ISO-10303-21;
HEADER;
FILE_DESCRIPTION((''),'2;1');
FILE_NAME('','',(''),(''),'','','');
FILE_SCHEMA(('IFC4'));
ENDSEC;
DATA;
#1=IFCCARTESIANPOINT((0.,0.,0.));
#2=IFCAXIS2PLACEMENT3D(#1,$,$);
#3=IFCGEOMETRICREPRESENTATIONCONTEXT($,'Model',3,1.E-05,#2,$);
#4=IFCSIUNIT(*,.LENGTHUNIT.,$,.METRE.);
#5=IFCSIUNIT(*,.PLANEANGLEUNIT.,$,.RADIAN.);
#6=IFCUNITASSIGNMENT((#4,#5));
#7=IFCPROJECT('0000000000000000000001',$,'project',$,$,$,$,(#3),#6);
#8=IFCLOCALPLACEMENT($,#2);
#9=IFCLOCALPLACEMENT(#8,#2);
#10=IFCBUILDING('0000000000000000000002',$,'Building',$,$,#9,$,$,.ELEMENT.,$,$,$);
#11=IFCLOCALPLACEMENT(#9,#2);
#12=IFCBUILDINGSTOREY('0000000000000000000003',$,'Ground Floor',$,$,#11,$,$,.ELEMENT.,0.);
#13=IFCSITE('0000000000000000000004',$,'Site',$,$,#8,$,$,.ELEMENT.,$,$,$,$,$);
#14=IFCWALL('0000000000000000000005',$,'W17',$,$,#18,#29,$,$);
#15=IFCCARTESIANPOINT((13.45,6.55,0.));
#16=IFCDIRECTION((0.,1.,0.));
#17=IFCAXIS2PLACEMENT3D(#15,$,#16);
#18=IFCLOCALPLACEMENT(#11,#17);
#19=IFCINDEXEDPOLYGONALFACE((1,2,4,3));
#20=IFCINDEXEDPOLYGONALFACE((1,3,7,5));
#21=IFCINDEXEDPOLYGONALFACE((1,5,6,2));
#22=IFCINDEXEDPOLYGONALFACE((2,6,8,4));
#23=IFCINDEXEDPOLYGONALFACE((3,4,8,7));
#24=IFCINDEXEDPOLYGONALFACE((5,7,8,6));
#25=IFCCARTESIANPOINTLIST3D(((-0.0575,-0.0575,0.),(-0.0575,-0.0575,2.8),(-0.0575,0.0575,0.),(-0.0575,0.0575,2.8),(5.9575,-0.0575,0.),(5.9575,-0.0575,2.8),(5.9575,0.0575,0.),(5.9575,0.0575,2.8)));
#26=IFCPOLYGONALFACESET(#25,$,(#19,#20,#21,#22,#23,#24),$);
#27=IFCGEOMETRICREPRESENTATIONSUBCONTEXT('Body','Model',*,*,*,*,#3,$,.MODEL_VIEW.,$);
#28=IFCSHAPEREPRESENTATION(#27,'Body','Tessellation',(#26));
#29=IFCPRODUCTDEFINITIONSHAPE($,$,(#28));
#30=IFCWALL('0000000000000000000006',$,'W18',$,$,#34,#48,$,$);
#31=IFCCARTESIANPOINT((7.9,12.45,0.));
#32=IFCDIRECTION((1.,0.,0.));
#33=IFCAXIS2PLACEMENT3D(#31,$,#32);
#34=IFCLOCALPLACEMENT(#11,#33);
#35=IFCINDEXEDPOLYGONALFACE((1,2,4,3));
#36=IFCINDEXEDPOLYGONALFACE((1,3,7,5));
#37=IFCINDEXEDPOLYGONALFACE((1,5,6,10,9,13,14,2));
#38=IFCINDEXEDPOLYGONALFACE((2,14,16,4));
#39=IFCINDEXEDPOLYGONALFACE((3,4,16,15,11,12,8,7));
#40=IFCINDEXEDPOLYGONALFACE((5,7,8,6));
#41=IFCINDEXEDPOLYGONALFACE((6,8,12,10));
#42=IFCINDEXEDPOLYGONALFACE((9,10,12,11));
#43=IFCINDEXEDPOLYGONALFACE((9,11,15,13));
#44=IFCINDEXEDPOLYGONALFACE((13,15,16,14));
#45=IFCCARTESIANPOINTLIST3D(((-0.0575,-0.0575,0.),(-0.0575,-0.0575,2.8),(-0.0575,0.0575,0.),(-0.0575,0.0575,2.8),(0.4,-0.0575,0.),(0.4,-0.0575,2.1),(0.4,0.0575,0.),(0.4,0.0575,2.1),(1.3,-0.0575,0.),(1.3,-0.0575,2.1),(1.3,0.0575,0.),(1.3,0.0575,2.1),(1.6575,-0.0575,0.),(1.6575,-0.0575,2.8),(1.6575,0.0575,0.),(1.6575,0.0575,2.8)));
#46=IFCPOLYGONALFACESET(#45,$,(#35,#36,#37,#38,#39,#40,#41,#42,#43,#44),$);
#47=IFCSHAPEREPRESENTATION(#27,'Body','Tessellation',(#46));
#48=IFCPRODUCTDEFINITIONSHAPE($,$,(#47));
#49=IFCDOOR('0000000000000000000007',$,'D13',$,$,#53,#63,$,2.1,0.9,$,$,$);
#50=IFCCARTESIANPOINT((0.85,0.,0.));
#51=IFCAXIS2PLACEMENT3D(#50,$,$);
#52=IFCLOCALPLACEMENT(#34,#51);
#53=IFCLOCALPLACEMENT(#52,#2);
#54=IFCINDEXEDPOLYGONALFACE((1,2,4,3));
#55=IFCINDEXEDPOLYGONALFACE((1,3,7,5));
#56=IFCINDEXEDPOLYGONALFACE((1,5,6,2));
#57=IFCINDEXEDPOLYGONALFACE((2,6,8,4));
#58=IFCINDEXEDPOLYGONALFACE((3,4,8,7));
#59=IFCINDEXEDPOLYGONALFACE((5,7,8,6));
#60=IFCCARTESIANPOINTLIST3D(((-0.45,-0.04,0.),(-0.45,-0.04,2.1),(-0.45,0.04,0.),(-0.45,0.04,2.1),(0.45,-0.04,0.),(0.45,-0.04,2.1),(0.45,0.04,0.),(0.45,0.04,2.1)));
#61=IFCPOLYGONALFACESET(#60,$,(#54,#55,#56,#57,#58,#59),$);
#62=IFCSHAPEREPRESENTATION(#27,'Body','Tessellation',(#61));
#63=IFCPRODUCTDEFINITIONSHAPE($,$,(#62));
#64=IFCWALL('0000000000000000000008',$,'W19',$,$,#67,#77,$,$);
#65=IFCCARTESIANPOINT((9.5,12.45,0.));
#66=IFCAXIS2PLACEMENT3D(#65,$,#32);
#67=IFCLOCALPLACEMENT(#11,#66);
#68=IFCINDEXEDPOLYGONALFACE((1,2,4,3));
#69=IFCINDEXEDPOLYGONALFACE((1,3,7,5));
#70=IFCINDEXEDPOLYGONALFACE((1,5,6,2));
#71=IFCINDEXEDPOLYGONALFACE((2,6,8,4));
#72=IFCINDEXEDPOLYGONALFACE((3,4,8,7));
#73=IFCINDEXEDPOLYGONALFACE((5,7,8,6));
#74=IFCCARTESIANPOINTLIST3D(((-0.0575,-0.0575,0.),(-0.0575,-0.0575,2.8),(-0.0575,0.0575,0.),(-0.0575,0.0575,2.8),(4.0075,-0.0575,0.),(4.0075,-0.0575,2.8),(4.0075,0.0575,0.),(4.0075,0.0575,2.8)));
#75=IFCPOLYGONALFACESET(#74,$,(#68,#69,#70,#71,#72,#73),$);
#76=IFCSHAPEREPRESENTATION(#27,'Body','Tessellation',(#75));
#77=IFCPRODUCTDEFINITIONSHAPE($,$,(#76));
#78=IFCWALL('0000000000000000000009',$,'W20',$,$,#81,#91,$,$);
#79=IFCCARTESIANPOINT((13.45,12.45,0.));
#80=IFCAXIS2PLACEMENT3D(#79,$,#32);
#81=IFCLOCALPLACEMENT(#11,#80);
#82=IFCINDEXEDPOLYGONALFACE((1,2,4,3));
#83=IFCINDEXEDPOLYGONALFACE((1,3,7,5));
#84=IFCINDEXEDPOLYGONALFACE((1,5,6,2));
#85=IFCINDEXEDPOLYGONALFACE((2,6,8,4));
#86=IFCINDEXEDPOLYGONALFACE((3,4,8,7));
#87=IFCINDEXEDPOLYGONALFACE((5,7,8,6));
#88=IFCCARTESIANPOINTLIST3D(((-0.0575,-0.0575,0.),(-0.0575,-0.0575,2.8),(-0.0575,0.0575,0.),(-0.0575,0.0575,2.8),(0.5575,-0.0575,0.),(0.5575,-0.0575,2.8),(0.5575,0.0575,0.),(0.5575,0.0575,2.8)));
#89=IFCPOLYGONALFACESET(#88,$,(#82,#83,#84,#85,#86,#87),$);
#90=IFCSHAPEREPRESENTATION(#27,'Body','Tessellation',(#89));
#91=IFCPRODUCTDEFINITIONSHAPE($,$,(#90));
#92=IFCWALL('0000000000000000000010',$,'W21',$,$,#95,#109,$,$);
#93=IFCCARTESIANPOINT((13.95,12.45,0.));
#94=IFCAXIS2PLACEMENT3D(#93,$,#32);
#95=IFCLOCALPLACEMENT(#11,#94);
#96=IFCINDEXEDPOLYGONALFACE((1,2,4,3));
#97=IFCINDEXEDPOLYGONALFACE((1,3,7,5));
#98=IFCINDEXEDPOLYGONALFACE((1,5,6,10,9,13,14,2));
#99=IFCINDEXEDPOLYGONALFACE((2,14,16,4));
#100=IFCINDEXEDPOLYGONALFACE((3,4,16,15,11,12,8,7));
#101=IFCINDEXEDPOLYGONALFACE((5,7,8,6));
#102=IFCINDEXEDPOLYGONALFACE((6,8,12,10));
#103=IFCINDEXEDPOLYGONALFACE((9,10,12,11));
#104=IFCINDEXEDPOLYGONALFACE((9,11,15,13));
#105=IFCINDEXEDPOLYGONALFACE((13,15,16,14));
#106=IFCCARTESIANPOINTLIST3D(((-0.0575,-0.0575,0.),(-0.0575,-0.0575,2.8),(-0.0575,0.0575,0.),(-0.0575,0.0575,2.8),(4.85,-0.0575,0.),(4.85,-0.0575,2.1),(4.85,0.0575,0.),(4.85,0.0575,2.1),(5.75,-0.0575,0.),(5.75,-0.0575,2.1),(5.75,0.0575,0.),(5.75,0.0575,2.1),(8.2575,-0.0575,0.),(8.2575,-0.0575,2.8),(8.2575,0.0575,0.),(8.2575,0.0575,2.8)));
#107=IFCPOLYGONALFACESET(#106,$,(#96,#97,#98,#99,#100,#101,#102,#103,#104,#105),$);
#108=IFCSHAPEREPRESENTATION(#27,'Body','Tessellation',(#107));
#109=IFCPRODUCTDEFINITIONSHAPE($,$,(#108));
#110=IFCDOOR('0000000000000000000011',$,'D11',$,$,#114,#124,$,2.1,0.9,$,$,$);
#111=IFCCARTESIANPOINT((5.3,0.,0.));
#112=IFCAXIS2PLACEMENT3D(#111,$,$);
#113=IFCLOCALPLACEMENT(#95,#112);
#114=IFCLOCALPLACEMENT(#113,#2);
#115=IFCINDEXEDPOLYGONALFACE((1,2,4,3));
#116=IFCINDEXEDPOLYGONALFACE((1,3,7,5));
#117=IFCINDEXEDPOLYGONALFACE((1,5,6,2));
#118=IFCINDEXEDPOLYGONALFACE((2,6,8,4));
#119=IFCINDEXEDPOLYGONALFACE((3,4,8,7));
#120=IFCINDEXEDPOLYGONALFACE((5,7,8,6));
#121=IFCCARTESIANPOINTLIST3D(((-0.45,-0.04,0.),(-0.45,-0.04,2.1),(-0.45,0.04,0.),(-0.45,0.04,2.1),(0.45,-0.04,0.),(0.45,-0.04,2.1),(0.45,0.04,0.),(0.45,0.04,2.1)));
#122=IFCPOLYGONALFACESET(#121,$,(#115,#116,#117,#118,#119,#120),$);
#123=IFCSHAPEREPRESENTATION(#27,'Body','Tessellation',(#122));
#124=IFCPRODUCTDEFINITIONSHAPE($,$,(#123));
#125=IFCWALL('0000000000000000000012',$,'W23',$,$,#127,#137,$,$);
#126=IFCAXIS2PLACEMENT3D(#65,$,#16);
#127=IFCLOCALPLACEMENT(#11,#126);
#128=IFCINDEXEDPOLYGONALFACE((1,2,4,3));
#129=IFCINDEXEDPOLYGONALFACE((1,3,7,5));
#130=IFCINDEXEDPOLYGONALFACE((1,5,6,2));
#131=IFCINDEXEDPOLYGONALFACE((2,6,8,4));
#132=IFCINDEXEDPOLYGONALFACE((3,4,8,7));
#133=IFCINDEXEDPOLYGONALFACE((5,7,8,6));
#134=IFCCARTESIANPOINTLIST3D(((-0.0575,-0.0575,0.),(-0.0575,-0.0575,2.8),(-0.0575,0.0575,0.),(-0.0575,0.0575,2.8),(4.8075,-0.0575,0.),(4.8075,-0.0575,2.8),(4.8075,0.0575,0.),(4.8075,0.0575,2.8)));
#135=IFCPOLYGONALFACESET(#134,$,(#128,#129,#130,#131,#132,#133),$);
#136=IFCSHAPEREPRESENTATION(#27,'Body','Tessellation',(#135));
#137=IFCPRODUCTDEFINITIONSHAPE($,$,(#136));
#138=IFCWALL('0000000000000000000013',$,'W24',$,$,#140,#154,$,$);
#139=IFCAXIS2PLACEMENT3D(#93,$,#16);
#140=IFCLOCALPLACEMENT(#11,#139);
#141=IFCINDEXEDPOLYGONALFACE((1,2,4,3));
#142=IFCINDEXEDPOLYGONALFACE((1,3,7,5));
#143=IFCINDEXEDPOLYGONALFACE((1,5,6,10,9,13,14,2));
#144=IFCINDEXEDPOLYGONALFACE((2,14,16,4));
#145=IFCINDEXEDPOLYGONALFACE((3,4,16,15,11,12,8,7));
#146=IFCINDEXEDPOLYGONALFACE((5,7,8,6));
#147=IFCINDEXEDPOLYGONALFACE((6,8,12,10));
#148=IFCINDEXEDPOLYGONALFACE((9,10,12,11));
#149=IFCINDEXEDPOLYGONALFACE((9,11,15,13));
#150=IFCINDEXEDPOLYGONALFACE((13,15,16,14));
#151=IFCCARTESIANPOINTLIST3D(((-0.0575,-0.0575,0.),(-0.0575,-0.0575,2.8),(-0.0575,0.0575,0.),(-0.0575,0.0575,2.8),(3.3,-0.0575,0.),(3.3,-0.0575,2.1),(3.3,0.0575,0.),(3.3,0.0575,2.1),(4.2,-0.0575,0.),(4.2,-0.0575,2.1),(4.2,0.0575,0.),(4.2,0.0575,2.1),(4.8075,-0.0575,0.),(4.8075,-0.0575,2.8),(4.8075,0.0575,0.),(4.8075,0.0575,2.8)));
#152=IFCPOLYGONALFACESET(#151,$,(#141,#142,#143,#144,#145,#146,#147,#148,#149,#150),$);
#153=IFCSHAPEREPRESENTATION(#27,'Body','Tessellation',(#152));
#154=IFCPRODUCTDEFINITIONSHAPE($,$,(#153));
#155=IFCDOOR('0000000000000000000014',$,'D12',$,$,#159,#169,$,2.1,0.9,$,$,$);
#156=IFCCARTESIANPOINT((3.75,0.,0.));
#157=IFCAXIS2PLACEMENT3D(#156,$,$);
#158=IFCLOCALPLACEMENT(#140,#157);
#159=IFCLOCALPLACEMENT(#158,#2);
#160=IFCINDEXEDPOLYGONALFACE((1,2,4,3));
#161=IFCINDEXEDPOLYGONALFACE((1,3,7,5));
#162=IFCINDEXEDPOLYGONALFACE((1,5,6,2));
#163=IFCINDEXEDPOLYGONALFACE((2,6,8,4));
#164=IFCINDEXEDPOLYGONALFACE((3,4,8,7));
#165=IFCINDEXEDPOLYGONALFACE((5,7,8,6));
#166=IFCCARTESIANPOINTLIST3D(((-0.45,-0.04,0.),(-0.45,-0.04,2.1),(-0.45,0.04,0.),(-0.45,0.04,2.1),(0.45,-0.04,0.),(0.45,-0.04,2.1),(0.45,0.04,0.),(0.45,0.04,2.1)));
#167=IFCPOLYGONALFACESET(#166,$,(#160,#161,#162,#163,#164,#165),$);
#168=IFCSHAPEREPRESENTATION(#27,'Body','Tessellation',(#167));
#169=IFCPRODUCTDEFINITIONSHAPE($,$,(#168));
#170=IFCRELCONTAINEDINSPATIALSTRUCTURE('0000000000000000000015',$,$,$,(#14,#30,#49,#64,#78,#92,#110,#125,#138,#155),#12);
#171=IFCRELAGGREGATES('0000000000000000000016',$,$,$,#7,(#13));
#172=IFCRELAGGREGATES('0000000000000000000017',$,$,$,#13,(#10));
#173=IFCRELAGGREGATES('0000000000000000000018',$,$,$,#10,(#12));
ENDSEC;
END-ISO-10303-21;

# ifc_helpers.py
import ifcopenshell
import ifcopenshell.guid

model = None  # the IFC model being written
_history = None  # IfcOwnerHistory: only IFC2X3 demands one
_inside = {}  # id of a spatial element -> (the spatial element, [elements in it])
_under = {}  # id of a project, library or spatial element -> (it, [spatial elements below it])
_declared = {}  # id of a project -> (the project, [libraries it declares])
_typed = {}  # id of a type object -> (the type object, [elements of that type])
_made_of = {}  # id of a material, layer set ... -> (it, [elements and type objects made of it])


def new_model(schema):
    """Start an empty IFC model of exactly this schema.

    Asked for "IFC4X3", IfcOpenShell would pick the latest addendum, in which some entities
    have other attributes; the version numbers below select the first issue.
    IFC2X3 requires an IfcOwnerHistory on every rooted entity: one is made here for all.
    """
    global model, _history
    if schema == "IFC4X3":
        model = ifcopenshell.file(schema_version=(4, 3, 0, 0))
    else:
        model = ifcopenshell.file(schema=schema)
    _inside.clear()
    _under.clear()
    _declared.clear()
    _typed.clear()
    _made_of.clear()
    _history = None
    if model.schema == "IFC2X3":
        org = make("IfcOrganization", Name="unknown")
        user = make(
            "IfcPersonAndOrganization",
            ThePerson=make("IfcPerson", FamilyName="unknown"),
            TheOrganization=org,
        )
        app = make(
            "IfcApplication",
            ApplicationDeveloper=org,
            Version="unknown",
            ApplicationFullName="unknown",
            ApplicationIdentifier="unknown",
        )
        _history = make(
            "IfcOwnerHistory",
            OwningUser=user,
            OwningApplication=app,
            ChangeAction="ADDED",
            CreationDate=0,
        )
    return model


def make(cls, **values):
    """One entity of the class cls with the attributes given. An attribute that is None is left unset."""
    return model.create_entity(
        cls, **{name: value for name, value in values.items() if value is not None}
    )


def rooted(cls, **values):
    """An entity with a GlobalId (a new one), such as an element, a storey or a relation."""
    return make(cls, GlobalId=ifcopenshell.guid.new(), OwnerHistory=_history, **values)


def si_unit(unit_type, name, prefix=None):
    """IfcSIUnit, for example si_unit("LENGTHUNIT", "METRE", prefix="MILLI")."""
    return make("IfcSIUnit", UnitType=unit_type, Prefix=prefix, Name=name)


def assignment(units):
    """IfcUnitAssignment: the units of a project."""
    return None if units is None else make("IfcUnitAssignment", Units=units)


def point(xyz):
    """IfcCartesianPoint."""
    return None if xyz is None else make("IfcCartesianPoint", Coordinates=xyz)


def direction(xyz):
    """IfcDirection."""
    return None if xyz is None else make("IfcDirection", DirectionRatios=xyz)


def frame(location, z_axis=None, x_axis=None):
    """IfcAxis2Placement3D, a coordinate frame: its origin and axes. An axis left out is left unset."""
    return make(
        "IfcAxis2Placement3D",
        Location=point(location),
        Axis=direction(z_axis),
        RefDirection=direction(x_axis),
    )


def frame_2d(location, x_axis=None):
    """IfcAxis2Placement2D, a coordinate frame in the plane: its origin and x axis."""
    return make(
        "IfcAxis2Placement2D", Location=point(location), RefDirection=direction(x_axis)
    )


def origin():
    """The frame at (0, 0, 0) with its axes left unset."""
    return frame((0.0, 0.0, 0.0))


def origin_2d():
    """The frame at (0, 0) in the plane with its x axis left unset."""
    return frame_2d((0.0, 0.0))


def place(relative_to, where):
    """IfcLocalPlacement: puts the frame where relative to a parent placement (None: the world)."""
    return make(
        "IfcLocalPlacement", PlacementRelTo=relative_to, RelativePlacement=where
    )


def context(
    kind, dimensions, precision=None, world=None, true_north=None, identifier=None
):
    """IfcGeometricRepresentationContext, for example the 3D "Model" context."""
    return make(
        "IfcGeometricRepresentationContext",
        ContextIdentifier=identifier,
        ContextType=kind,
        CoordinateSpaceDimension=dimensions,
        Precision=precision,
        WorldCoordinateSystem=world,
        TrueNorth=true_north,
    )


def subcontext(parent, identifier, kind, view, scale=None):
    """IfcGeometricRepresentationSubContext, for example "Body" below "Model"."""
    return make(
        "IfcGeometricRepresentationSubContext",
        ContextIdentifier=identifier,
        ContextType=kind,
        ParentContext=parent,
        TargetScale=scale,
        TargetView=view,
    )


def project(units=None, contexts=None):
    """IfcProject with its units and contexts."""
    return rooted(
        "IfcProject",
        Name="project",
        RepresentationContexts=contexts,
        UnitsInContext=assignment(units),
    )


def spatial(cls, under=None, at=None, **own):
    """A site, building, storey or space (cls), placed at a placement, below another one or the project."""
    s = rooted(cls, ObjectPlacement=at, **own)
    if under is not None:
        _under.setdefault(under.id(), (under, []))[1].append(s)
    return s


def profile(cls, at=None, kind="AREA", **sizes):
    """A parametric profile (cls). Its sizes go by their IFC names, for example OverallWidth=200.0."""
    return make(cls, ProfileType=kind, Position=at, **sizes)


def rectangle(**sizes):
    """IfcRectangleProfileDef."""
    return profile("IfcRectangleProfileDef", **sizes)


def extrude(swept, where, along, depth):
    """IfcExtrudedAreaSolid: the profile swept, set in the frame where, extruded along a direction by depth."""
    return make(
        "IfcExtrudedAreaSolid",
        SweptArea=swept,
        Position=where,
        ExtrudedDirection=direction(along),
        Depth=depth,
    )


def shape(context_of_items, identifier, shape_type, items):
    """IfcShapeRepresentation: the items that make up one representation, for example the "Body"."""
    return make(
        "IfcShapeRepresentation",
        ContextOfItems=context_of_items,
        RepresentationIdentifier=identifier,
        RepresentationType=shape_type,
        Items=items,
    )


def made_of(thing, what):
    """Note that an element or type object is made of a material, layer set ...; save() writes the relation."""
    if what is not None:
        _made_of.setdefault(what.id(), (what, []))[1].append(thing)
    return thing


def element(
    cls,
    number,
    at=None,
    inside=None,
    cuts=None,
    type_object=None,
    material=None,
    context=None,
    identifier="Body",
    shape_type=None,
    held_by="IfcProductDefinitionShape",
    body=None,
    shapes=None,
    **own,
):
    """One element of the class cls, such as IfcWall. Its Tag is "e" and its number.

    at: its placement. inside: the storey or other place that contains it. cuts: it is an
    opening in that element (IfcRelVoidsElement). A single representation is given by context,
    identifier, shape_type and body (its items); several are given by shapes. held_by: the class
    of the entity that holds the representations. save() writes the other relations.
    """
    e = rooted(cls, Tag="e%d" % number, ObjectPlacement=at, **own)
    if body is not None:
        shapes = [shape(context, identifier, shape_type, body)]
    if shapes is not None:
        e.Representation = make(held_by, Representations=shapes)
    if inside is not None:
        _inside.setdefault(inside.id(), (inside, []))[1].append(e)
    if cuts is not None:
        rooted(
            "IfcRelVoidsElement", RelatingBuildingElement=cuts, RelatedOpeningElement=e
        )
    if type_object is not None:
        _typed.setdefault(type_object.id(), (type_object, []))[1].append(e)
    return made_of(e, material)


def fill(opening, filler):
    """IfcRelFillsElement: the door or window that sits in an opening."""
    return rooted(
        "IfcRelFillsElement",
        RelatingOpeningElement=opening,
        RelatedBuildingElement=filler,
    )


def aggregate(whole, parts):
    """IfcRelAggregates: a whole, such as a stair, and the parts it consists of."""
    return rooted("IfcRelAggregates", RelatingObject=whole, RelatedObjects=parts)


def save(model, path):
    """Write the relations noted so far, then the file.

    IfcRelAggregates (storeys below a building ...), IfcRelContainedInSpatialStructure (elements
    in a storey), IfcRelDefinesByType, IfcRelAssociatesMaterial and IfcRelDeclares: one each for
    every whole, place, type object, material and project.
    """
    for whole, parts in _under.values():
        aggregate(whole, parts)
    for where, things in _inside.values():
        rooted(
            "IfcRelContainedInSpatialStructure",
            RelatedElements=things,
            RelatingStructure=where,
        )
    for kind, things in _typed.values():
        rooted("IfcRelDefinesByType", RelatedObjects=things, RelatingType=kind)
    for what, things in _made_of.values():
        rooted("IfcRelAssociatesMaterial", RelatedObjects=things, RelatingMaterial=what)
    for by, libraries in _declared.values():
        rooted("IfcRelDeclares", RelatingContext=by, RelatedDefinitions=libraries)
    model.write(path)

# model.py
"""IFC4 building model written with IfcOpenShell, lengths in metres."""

from ifc_helpers import new_model, si_unit, frame, frame_2d, origin, origin_2d, place, context, subcontext, project, spatial, rectangle, extrude, element, fill, save


model = new_model("IFC4")

# Units and contexts
model_context = context("Model", 3, precision=1e-05, world=origin())
body_context = subcontext(model_context, "Body", "Model", "MODEL_VIEW")
ifc_project = project(units=[si_unit("LENGTHUNIT", "METRE"), si_unit("PLANEANGLEUNIT", "RADIAN")], contexts=[model_context])

# Site, building, storey
site_placement = place(None, origin())
site = spatial("IfcSite", under=ifc_project, at=site_placement, Name="Site", CompositionType="ELEMENT")
building_placement = place(site_placement, origin())
building = spatial("IfcBuilding", under=site, at=building_placement, Name="Building", CompositionType="ELEMENT")
storey_placement = place(building_placement, origin())
storey = spatial("IfcBuildingStorey", under=building, at=storey_placement, Name="Ground Floor", CompositionType="ELEMENT", Elevation=0.0)

# Wall
wall_1_placement = place(storey_placement, frame((13.45, 6.55, 0.0), x_axis=(0.0, 1.0, 0.0)))
element("IfcWall", 1, at=wall_1_placement, inside=storey, Name="W17", context=body_context, shape_type="SweptSolid", body=[
    extrude(rectangle(XDim=6.015, YDim=0.115, at=frame_2d((2.95, 0.0))), origin(), (0.0, 0.0, 1.0), 2.8),
])

# Wall, opening, door
wall_2_placement = place(storey_placement, frame((7.9, 12.45, 0.0), x_axis=(1.0, 0.0, 0.0)))
wall_2 = element("IfcWall", 2, at=wall_2_placement, inside=storey, Name="W18", context=body_context, shape_type="SweptSolid", body=[
    extrude(rectangle(XDim=1.715, YDim=0.115, at=frame_2d((0.8, 0.0))), origin(), (0.0, 0.0, 1.0), 2.8),
])
opening_1_placement = place(wall_2_placement, frame((0.85, 0.0, 0.0)))
opening_1 = element("IfcOpeningElement", 3, at=opening_1_placement, cuts=wall_2, context=body_context, shape_type="SweptSolid", body=[
    extrude(rectangle(XDim=0.9, YDim=0.215, at=origin_2d()), origin(), (0.0, 0.0, 1.0), 2.1),
])
door_1_placement = place(opening_1_placement, origin())
door_1 = element("IfcDoor", 4, at=door_1_placement, inside=storey, Name="D13", OverallHeight=2.1, OverallWidth=0.9, context=body_context, shape_type="SweptSolid", body=[
    extrude(rectangle(XDim=0.9, YDim=0.08, at=origin_2d()), origin(), (0.0, 0.0, 1.0), 2.1),
])
fill(opening_1, door_1)

# Walls
wall_3_placement = place(storey_placement, frame((9.5, 12.45, 0.0), x_axis=(1.0, 0.0, 0.0)))
element("IfcWall", 5, at=wall_3_placement, inside=storey, Name="W19", context=body_context, shape_type="SweptSolid", body=[
    extrude(rectangle(XDim=4.065, YDim=0.115, at=frame_2d((1.975, 0.0))), origin(), (0.0, 0.0, 1.0), 2.8),
])
wall_4_placement = place(storey_placement, frame((13.45, 12.45, 0.0), x_axis=(1.0, 0.0, 0.0)))
element("IfcWall", 6, at=wall_4_placement, inside=storey, Name="W20", context=body_context, shape_type="SweptSolid", body=[
    extrude(rectangle(XDim=0.615, YDim=0.115, at=frame_2d((0.25, 0.0))), origin(), (0.0, 0.0, 1.0), 2.8),
])

# Wall, opening, door
wall_5_placement = place(storey_placement, frame((13.95, 12.45, 0.0), x_axis=(1.0, 0.0, 0.0)))
wall_5 = element("IfcWall", 7, at=wall_5_placement, inside=storey, Name="W21", context=body_context, shape_type="SweptSolid", body=[
    extrude(rectangle(XDim=8.315, YDim=0.115, at=frame_2d((4.1, 0.0))), origin(), (0.0, 0.0, 1.0), 2.8),
])
opening_2_placement = place(wall_5_placement, frame((5.3, 0.0, 0.0)))
opening_2 = element("IfcOpeningElement", 8, at=opening_2_placement, cuts=wall_5, context=body_context, shape_type="SweptSolid", body=[
    extrude(rectangle(XDim=0.9, YDim=0.215, at=origin_2d()), origin(), (0.0, 0.0, 1.0), 2.1),
])
door_2_placement = place(opening_2_placement, origin())
door_2 = element("IfcDoor", 9, at=door_2_placement, inside=storey, Name="D11", OverallHeight=2.1, OverallWidth=0.9, context=body_context, shape_type="SweptSolid", body=[
    extrude(rectangle(XDim=0.9, YDim=0.08, at=origin_2d()), origin(), (0.0, 0.0, 1.0), 2.1),
])
fill(opening_2, door_2)

# Wall
wall_6_placement = place(storey_placement, frame((9.5, 12.45, 0.0), x_axis=(0.0, 1.0, 0.0)))
element("IfcWall", 10, at=wall_6_placement, inside=storey, Name="W23", context=body_context, shape_type="SweptSolid", body=[
    extrude(rectangle(XDim=4.865, YDim=0.115, at=frame_2d((2.375, 0.0))), origin(), (0.0, 0.0, 1.0), 2.8),
])

# Wall, opening, door
wall_7_placement = place(storey_placement, frame((13.95, 12.45, 0.0), x_axis=(0.0, 1.0, 0.0)))
wall_7 = element("IfcWall", 11, at=wall_7_placement, inside=storey, Name="W24", context=body_context, shape_type="SweptSolid", body=[
    extrude(rectangle(XDim=4.865, YDim=0.115, at=frame_2d((2.375, 0.0))), origin(), (0.0, 0.0, 1.0), 2.8),
])
opening_3_placement = place(wall_7_placement, frame((3.75, 0.0, 0.0)))
opening_3 = element("IfcOpeningElement", 12, at=opening_3_placement, cuts=wall_7, context=body_context, shape_type="SweptSolid", body=[
    extrude(rectangle(XDim=0.9, YDim=0.215, at=origin_2d()), origin(), (0.0, 0.0, 1.0), 2.1),
])
door_3_placement = place(opening_3_placement, origin())
door_3 = element("IfcDoor", 13, at=door_3_placement, inside=storey, Name="D12", OverallHeight=2.1, OverallWidth=0.9, context=body_context, shape_type="SweptSolid", body=[
    extrude(rectangle(XDim=0.9, YDim=0.08, at=origin_2d()), origin(), (0.0, 0.0, 1.0), 2.1),
])
fill(opening_3, door_3)

save(model, "model.ifc")
